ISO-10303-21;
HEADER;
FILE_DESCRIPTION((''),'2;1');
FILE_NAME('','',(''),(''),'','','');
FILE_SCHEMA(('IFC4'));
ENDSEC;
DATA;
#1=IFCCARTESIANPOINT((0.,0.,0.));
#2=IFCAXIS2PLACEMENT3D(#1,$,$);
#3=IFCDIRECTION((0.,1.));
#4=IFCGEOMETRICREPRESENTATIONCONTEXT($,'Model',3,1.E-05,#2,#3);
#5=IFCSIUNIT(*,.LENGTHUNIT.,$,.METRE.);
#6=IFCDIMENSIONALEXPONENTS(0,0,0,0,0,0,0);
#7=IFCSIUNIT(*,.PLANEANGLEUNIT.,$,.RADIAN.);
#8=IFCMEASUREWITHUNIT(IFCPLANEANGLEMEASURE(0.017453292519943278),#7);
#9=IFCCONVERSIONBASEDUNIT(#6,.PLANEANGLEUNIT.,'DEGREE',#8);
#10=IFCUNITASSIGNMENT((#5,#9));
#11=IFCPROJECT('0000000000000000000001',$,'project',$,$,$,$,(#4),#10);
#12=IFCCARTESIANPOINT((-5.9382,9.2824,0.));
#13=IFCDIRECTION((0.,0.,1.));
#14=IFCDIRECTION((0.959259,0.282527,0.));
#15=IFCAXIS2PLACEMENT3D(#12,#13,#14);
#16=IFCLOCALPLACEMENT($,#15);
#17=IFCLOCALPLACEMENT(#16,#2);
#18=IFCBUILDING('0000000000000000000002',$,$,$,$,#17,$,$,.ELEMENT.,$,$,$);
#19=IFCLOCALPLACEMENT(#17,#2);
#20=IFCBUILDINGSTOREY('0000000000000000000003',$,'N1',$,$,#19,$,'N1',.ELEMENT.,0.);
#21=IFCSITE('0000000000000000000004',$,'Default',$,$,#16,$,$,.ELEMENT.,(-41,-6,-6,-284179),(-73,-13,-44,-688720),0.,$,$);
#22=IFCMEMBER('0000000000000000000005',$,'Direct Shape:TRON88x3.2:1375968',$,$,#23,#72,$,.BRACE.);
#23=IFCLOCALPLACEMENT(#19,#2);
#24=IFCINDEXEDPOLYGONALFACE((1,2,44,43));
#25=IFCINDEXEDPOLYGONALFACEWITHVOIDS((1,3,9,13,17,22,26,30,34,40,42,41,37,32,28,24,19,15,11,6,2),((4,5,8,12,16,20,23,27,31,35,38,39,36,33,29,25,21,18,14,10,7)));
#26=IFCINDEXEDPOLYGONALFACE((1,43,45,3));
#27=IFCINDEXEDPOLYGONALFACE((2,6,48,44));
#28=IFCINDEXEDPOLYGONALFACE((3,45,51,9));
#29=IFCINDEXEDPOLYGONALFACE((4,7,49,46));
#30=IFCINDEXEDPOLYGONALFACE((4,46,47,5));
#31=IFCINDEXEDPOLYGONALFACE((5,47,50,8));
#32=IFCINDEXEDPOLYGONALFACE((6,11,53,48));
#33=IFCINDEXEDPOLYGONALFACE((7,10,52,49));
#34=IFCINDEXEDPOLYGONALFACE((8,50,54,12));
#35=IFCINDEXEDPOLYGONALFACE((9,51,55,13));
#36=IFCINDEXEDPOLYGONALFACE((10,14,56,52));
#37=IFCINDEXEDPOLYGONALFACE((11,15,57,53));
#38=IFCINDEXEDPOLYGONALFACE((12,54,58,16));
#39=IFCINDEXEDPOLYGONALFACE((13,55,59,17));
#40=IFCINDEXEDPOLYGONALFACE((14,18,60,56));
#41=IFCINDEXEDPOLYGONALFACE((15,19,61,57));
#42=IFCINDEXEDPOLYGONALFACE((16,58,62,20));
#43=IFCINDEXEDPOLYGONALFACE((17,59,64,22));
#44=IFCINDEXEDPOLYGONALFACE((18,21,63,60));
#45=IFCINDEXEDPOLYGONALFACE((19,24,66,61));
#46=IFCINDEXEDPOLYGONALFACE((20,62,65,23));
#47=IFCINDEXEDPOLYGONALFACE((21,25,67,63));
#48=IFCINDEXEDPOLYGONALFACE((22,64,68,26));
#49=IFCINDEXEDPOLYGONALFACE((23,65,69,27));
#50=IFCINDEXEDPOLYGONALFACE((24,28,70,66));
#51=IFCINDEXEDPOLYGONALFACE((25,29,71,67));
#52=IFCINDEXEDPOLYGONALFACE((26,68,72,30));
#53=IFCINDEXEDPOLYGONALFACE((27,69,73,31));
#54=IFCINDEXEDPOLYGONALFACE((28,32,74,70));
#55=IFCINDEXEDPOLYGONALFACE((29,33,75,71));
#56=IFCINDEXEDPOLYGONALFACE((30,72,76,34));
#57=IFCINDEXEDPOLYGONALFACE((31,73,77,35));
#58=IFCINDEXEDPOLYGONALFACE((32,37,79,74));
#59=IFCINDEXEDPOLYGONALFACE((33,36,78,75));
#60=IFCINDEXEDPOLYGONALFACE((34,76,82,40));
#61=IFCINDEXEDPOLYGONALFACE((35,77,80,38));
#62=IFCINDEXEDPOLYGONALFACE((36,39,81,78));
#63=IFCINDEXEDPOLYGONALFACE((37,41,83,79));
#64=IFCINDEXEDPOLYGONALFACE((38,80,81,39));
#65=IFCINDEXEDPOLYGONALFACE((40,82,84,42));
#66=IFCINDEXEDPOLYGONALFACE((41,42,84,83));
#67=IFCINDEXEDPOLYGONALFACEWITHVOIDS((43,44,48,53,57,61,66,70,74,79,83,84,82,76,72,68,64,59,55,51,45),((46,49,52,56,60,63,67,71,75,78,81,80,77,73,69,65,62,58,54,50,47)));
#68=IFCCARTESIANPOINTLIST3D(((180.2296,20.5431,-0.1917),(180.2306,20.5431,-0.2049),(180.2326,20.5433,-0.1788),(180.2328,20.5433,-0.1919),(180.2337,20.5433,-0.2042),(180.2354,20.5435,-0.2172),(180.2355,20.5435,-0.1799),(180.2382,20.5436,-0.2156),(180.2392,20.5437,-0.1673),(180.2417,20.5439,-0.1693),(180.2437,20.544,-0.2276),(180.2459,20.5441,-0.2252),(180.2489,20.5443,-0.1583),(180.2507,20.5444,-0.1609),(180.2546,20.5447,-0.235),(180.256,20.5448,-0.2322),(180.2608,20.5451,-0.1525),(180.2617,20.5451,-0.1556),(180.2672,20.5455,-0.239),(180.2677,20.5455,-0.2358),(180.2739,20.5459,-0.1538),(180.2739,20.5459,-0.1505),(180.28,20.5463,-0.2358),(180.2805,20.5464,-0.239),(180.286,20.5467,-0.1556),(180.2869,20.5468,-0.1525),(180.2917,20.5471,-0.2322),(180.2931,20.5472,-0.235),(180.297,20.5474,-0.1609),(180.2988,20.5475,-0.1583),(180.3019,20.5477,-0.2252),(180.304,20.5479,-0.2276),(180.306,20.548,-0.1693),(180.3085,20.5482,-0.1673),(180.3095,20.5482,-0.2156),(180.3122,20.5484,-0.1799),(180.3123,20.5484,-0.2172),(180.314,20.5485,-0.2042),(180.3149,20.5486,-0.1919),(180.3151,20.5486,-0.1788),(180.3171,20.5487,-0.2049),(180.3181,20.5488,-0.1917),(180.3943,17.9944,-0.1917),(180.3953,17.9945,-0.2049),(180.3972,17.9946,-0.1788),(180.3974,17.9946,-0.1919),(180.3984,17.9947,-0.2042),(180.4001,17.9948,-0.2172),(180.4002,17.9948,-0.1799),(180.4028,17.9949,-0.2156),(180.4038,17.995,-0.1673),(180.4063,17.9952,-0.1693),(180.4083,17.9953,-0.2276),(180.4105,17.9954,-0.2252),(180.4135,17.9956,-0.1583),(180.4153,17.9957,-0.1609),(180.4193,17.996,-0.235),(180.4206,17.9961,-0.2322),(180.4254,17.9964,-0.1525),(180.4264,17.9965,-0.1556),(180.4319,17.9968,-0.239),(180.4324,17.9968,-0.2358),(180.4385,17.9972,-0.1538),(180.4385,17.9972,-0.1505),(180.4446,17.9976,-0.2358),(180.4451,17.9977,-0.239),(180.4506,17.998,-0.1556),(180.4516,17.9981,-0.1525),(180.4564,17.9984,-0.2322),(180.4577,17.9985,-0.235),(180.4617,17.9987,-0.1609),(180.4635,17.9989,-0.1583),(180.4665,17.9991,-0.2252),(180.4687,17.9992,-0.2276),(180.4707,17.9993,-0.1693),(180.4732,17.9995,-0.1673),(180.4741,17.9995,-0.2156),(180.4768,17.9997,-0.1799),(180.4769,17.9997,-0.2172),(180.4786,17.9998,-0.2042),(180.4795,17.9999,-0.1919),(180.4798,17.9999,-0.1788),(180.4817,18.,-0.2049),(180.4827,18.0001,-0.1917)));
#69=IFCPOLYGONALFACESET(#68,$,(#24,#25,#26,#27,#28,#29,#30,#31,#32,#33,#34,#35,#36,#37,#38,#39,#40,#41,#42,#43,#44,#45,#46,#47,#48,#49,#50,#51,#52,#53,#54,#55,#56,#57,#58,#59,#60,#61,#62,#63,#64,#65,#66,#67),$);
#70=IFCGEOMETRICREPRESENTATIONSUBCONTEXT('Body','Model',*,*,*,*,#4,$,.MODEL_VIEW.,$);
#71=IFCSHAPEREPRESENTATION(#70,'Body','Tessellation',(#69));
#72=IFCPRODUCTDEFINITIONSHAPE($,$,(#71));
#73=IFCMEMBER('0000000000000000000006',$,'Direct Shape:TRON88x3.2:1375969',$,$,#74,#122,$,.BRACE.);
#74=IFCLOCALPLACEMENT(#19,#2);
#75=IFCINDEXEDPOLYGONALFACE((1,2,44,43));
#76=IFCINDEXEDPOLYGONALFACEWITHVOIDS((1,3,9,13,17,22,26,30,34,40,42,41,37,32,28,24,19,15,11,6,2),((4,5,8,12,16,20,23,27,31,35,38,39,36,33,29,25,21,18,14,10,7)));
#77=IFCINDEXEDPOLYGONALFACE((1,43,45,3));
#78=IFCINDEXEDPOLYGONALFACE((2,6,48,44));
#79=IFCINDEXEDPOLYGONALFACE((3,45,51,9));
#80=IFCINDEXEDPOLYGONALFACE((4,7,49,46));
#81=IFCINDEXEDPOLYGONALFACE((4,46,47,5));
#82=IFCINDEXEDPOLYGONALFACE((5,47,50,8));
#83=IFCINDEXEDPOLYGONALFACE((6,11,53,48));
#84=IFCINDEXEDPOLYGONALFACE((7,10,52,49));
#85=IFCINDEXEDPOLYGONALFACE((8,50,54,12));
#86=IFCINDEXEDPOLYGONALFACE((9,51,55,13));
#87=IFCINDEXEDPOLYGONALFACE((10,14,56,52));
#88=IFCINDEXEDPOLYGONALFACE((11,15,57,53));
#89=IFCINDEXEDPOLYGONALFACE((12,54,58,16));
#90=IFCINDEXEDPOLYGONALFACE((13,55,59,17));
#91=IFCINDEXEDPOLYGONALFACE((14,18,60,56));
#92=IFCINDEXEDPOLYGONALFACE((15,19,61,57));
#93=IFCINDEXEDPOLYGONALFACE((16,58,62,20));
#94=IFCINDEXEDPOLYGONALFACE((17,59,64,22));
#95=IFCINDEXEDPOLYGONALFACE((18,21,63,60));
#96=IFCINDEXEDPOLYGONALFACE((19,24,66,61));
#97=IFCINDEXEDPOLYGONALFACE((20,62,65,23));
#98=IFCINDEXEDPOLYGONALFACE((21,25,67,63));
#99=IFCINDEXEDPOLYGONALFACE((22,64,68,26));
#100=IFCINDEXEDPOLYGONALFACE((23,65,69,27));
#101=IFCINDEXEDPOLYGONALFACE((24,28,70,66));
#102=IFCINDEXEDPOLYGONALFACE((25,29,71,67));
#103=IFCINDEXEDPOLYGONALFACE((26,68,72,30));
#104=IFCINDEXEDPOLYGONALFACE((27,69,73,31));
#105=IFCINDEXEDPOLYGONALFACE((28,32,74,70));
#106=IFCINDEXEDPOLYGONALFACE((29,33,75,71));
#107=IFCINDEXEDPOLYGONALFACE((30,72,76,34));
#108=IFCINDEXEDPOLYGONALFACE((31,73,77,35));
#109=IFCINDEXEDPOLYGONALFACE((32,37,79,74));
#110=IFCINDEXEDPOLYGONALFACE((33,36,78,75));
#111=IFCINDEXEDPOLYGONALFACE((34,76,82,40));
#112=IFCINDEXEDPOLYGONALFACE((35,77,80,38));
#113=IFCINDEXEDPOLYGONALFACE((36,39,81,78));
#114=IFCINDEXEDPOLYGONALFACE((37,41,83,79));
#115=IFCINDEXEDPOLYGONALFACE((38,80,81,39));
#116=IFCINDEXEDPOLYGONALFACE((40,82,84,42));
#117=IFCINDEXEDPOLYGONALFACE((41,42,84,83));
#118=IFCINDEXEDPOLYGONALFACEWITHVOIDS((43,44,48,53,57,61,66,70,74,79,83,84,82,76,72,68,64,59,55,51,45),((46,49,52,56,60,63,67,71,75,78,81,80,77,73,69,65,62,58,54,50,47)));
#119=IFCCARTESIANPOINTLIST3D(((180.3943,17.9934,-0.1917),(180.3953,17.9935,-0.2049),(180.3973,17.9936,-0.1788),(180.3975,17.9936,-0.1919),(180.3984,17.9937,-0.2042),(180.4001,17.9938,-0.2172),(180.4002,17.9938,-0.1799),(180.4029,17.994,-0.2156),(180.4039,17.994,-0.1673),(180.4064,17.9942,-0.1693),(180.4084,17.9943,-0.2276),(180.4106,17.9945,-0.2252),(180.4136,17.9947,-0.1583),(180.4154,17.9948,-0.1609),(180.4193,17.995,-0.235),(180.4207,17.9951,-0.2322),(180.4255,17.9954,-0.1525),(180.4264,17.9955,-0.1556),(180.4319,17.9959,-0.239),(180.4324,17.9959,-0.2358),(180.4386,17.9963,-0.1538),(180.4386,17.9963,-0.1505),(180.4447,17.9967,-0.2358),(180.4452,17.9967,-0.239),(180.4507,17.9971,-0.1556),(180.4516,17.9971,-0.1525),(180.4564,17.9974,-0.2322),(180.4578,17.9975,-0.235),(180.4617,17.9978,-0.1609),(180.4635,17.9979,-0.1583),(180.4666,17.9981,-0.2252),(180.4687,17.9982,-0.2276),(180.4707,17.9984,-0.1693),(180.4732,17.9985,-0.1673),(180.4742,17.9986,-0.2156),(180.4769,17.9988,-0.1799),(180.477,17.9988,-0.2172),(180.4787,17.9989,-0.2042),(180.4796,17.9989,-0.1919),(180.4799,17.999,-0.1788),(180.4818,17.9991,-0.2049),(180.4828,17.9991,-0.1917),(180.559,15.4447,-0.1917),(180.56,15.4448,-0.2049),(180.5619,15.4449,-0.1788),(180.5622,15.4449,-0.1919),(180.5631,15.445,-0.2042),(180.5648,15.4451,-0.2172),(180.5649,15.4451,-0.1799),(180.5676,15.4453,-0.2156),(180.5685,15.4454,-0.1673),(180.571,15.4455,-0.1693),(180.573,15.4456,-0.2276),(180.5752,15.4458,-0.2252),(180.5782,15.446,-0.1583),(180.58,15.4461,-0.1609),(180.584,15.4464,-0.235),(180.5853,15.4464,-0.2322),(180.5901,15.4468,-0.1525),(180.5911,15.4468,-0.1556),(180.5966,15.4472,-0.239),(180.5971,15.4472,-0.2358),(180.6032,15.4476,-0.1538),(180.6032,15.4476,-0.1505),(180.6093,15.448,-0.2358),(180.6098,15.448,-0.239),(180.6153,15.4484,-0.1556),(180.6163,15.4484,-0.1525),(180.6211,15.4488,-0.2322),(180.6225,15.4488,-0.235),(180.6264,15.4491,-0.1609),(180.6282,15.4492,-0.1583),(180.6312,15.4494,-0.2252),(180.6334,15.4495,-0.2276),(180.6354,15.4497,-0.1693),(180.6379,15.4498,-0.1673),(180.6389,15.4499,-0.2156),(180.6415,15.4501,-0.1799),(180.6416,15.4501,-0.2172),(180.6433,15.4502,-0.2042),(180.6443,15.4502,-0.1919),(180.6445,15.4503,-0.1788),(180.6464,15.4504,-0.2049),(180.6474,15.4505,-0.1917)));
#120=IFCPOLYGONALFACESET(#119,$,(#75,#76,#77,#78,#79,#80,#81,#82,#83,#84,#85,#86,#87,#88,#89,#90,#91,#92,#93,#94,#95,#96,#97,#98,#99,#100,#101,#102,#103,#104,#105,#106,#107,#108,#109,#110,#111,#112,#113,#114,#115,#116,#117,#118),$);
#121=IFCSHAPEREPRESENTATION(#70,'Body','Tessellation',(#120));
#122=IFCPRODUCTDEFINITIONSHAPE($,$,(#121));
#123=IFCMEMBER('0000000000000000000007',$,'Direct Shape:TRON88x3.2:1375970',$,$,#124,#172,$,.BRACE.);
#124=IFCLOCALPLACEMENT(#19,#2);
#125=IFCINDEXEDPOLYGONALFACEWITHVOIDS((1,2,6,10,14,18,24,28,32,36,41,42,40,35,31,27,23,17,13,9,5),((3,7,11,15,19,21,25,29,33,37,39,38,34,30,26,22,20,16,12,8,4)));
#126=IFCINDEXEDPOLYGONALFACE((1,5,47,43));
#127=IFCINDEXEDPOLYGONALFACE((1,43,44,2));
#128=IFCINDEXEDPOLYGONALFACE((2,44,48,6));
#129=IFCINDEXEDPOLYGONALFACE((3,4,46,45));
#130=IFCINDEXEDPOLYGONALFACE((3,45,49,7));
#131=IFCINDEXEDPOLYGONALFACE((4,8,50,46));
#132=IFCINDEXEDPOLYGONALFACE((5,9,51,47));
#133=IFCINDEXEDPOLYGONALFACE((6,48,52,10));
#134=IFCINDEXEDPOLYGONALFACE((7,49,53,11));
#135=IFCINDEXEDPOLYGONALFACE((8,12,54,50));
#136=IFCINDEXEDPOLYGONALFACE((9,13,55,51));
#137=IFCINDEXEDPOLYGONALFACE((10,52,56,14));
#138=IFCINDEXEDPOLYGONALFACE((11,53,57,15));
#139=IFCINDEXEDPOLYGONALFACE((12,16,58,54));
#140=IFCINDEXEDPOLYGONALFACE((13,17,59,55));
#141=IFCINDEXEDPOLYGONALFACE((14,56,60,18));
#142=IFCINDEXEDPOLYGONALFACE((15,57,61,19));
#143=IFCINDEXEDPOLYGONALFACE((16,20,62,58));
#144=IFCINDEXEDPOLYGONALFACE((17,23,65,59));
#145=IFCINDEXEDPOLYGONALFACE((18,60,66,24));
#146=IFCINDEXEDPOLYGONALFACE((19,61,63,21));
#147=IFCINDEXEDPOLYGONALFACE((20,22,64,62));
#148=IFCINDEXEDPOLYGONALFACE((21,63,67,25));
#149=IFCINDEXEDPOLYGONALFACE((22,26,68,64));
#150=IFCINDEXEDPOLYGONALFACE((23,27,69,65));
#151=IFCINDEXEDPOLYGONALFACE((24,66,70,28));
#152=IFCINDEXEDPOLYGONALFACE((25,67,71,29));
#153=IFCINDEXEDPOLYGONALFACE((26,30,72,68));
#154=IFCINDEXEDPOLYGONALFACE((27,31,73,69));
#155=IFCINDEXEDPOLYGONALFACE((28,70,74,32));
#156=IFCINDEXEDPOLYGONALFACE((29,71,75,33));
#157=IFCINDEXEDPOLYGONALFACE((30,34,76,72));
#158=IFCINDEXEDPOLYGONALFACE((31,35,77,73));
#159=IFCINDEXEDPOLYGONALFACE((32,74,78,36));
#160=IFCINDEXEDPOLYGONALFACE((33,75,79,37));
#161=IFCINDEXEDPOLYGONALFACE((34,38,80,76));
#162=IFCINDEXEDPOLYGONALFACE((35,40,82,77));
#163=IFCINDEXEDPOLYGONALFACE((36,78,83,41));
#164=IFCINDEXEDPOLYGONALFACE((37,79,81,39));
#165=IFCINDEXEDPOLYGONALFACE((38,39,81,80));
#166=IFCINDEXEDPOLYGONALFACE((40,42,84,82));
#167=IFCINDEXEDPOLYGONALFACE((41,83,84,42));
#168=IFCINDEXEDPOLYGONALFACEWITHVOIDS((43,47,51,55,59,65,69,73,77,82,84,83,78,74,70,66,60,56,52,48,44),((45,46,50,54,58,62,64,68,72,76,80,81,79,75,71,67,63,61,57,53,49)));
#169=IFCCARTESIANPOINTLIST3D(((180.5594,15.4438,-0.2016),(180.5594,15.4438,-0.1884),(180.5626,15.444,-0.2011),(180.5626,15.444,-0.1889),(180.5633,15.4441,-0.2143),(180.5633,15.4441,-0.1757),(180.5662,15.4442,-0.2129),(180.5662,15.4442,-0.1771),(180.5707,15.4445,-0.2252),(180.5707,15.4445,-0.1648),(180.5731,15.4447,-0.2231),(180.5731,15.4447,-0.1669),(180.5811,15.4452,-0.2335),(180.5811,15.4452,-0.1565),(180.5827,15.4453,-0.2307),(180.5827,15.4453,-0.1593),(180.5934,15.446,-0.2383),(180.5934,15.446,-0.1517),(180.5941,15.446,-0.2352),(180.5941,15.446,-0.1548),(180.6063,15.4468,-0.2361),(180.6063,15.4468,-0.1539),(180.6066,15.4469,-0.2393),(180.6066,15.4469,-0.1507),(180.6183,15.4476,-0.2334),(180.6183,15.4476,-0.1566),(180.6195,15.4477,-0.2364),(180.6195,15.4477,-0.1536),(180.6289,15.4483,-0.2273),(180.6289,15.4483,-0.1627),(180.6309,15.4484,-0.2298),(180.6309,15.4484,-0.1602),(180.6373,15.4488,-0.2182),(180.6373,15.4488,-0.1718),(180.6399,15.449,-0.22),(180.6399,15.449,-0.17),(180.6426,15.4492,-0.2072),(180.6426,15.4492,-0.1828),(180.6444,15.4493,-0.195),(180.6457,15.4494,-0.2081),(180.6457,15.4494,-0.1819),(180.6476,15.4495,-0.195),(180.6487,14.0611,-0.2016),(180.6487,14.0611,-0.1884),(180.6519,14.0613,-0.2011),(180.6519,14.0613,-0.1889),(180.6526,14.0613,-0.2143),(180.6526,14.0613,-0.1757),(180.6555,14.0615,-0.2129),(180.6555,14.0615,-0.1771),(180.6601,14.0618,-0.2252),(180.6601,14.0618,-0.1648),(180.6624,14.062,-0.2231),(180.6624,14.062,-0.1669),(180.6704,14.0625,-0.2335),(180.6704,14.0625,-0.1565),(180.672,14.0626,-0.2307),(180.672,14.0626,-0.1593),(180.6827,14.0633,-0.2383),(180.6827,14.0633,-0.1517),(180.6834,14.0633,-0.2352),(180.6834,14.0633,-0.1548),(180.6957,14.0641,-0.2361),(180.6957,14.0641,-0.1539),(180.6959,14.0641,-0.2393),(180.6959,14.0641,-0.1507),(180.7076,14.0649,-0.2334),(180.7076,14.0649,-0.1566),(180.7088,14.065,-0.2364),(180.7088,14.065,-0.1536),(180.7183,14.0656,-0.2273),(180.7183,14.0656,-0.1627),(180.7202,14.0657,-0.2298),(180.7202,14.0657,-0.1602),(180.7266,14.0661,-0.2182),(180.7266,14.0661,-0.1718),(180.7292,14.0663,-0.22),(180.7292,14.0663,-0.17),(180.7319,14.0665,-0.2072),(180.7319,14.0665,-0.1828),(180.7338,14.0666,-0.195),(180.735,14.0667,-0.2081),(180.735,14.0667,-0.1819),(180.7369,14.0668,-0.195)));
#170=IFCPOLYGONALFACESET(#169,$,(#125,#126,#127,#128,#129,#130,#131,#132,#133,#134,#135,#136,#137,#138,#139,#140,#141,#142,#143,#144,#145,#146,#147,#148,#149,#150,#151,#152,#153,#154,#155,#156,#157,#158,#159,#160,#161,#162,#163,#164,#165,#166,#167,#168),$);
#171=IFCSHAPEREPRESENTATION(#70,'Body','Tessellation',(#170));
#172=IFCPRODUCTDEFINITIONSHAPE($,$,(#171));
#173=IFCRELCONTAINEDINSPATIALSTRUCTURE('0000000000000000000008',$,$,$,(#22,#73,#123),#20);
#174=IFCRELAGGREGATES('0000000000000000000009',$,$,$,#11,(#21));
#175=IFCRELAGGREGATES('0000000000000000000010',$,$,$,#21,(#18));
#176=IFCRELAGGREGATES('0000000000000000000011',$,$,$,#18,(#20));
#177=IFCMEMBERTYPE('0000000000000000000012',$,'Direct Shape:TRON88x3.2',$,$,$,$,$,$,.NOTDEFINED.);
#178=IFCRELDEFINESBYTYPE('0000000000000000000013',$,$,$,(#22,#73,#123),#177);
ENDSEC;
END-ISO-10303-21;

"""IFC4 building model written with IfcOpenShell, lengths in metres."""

from ifc_helpers import new_model, entity, si_unit, converted_unit, direction, frame, frame_2d, origin, place, context, subcontext, project, spatial, hollow_circle, extrude, type_object, element, save


model = new_model("IFC4")

# Units and contexts
model_context = context("Model", 3, precision=1e-05, world=origin(), true_north=direction((0.0, 1.0)))
body_context = subcontext(model_context, "Body", "Model", "MODEL_VIEW")
ifc_project = project(units=[si_unit("LENGTHUNIT", "METRE"), converted_unit("PLANEANGLEUNIT", "DEGREE", entity("IfcPlaneAngleMeasure", 0.017453292519943278), si_unit("PLANEANGLEUNIT", "RADIAN"), dimensions=[0, 0, 0, 0, 0, 0, 0])], contexts=[model_context])

# Site, building, storey
site_placement = place(None, frame((-5.9382, 9.2824, 0.0), z_axis=(0.0, 0.0, 1.0), x_axis=(0.959259, 0.282527, 0.0)))
site = spatial("IfcSite", under=ifc_project, at=site_placement, Name="Default", CompositionType="ELEMENT", RefLatitude=(-41, -6, -6, -284179), RefLongitude=(-73, -13, -44, -688720), RefElevation=0.0)
building_placement = place(site_placement, origin())
building = spatial("IfcBuilding", under=site, at=building_placement, CompositionType="ELEMENT")
storey_placement = place(building_placement, origin())
storey = spatial("IfcBuildingStorey", under=building, at=storey_placement, Name="N1", LongName="N1", CompositionType="ELEMENT", Elevation=0.0)

# Members
member_type_1 = type_object("IfcMemberType", Name="Direct Shape:TRON88x3.2", PredefinedType="NOTDEFINED")
member_1_placement = place(storey_placement, origin())
element("IfcMember", 1, at=member_1_placement, inside=storey, type_object=member_type_1, Name="Direct Shape:TRON88x3.2:1375968", PredefinedType="BRACE", context=body_context, shape_type="SweptSolid", body=[
    extrude(hollow_circle(Radius=0.0445, WallThickness=0.0032, at=frame_2d((0.0, 0.0), x_axis=(1.0, 0.0))), frame((180.4385, 17.9972, -0.195), z_axis=(-0.064465, 0.99792, 0.0), x_axis=(0.0, 0.0, 1.0)), (0.0, 0.0, 1.0), 2.554),
])
member_2_placement = place(storey_placement, origin())
element("IfcMember", 2, at=member_2_placement, inside=storey, type_object=member_type_1, Name="Direct Shape:TRON88x3.2:1375969", PredefinedType="BRACE", context=body_context, shape_type="SweptSolid", body=[
    extrude(hollow_circle(Radius=0.0445, WallThickness=0.0032, at=frame_2d((0.0, 0.0), x_axis=(1.0, 0.0))), frame((180.6032, 15.4476, -0.195), z_axis=(-0.064465, 0.99792, 0.0), x_axis=(0.0, 0.0, 1.0)), (0.0, 0.0, 1.0), 2.554),
])
member_3_placement = place(storey_placement, origin())
element("IfcMember", 3, at=member_3_placement, inside=storey, type_object=member_type_1, Name="Direct Shape:TRON88x3.2:1375970", PredefinedType="BRACE", context=body_context, shape_type="SweptSolid", body=[
    extrude(hollow_circle(Radius=0.0445, WallThickness=0.0032, at=frame_2d((0.0, 0.0), x_axis=(1.0, 0.0))), frame((180.6926, 14.0639, -0.195), z_axis=(-0.064471, 0.99792, 0.0), x_axis=(0.99792, 0.064471, 0.0)), (0.000006, 0.0, 1.0), 1.3856),
])

save(model, "model.ifc")
